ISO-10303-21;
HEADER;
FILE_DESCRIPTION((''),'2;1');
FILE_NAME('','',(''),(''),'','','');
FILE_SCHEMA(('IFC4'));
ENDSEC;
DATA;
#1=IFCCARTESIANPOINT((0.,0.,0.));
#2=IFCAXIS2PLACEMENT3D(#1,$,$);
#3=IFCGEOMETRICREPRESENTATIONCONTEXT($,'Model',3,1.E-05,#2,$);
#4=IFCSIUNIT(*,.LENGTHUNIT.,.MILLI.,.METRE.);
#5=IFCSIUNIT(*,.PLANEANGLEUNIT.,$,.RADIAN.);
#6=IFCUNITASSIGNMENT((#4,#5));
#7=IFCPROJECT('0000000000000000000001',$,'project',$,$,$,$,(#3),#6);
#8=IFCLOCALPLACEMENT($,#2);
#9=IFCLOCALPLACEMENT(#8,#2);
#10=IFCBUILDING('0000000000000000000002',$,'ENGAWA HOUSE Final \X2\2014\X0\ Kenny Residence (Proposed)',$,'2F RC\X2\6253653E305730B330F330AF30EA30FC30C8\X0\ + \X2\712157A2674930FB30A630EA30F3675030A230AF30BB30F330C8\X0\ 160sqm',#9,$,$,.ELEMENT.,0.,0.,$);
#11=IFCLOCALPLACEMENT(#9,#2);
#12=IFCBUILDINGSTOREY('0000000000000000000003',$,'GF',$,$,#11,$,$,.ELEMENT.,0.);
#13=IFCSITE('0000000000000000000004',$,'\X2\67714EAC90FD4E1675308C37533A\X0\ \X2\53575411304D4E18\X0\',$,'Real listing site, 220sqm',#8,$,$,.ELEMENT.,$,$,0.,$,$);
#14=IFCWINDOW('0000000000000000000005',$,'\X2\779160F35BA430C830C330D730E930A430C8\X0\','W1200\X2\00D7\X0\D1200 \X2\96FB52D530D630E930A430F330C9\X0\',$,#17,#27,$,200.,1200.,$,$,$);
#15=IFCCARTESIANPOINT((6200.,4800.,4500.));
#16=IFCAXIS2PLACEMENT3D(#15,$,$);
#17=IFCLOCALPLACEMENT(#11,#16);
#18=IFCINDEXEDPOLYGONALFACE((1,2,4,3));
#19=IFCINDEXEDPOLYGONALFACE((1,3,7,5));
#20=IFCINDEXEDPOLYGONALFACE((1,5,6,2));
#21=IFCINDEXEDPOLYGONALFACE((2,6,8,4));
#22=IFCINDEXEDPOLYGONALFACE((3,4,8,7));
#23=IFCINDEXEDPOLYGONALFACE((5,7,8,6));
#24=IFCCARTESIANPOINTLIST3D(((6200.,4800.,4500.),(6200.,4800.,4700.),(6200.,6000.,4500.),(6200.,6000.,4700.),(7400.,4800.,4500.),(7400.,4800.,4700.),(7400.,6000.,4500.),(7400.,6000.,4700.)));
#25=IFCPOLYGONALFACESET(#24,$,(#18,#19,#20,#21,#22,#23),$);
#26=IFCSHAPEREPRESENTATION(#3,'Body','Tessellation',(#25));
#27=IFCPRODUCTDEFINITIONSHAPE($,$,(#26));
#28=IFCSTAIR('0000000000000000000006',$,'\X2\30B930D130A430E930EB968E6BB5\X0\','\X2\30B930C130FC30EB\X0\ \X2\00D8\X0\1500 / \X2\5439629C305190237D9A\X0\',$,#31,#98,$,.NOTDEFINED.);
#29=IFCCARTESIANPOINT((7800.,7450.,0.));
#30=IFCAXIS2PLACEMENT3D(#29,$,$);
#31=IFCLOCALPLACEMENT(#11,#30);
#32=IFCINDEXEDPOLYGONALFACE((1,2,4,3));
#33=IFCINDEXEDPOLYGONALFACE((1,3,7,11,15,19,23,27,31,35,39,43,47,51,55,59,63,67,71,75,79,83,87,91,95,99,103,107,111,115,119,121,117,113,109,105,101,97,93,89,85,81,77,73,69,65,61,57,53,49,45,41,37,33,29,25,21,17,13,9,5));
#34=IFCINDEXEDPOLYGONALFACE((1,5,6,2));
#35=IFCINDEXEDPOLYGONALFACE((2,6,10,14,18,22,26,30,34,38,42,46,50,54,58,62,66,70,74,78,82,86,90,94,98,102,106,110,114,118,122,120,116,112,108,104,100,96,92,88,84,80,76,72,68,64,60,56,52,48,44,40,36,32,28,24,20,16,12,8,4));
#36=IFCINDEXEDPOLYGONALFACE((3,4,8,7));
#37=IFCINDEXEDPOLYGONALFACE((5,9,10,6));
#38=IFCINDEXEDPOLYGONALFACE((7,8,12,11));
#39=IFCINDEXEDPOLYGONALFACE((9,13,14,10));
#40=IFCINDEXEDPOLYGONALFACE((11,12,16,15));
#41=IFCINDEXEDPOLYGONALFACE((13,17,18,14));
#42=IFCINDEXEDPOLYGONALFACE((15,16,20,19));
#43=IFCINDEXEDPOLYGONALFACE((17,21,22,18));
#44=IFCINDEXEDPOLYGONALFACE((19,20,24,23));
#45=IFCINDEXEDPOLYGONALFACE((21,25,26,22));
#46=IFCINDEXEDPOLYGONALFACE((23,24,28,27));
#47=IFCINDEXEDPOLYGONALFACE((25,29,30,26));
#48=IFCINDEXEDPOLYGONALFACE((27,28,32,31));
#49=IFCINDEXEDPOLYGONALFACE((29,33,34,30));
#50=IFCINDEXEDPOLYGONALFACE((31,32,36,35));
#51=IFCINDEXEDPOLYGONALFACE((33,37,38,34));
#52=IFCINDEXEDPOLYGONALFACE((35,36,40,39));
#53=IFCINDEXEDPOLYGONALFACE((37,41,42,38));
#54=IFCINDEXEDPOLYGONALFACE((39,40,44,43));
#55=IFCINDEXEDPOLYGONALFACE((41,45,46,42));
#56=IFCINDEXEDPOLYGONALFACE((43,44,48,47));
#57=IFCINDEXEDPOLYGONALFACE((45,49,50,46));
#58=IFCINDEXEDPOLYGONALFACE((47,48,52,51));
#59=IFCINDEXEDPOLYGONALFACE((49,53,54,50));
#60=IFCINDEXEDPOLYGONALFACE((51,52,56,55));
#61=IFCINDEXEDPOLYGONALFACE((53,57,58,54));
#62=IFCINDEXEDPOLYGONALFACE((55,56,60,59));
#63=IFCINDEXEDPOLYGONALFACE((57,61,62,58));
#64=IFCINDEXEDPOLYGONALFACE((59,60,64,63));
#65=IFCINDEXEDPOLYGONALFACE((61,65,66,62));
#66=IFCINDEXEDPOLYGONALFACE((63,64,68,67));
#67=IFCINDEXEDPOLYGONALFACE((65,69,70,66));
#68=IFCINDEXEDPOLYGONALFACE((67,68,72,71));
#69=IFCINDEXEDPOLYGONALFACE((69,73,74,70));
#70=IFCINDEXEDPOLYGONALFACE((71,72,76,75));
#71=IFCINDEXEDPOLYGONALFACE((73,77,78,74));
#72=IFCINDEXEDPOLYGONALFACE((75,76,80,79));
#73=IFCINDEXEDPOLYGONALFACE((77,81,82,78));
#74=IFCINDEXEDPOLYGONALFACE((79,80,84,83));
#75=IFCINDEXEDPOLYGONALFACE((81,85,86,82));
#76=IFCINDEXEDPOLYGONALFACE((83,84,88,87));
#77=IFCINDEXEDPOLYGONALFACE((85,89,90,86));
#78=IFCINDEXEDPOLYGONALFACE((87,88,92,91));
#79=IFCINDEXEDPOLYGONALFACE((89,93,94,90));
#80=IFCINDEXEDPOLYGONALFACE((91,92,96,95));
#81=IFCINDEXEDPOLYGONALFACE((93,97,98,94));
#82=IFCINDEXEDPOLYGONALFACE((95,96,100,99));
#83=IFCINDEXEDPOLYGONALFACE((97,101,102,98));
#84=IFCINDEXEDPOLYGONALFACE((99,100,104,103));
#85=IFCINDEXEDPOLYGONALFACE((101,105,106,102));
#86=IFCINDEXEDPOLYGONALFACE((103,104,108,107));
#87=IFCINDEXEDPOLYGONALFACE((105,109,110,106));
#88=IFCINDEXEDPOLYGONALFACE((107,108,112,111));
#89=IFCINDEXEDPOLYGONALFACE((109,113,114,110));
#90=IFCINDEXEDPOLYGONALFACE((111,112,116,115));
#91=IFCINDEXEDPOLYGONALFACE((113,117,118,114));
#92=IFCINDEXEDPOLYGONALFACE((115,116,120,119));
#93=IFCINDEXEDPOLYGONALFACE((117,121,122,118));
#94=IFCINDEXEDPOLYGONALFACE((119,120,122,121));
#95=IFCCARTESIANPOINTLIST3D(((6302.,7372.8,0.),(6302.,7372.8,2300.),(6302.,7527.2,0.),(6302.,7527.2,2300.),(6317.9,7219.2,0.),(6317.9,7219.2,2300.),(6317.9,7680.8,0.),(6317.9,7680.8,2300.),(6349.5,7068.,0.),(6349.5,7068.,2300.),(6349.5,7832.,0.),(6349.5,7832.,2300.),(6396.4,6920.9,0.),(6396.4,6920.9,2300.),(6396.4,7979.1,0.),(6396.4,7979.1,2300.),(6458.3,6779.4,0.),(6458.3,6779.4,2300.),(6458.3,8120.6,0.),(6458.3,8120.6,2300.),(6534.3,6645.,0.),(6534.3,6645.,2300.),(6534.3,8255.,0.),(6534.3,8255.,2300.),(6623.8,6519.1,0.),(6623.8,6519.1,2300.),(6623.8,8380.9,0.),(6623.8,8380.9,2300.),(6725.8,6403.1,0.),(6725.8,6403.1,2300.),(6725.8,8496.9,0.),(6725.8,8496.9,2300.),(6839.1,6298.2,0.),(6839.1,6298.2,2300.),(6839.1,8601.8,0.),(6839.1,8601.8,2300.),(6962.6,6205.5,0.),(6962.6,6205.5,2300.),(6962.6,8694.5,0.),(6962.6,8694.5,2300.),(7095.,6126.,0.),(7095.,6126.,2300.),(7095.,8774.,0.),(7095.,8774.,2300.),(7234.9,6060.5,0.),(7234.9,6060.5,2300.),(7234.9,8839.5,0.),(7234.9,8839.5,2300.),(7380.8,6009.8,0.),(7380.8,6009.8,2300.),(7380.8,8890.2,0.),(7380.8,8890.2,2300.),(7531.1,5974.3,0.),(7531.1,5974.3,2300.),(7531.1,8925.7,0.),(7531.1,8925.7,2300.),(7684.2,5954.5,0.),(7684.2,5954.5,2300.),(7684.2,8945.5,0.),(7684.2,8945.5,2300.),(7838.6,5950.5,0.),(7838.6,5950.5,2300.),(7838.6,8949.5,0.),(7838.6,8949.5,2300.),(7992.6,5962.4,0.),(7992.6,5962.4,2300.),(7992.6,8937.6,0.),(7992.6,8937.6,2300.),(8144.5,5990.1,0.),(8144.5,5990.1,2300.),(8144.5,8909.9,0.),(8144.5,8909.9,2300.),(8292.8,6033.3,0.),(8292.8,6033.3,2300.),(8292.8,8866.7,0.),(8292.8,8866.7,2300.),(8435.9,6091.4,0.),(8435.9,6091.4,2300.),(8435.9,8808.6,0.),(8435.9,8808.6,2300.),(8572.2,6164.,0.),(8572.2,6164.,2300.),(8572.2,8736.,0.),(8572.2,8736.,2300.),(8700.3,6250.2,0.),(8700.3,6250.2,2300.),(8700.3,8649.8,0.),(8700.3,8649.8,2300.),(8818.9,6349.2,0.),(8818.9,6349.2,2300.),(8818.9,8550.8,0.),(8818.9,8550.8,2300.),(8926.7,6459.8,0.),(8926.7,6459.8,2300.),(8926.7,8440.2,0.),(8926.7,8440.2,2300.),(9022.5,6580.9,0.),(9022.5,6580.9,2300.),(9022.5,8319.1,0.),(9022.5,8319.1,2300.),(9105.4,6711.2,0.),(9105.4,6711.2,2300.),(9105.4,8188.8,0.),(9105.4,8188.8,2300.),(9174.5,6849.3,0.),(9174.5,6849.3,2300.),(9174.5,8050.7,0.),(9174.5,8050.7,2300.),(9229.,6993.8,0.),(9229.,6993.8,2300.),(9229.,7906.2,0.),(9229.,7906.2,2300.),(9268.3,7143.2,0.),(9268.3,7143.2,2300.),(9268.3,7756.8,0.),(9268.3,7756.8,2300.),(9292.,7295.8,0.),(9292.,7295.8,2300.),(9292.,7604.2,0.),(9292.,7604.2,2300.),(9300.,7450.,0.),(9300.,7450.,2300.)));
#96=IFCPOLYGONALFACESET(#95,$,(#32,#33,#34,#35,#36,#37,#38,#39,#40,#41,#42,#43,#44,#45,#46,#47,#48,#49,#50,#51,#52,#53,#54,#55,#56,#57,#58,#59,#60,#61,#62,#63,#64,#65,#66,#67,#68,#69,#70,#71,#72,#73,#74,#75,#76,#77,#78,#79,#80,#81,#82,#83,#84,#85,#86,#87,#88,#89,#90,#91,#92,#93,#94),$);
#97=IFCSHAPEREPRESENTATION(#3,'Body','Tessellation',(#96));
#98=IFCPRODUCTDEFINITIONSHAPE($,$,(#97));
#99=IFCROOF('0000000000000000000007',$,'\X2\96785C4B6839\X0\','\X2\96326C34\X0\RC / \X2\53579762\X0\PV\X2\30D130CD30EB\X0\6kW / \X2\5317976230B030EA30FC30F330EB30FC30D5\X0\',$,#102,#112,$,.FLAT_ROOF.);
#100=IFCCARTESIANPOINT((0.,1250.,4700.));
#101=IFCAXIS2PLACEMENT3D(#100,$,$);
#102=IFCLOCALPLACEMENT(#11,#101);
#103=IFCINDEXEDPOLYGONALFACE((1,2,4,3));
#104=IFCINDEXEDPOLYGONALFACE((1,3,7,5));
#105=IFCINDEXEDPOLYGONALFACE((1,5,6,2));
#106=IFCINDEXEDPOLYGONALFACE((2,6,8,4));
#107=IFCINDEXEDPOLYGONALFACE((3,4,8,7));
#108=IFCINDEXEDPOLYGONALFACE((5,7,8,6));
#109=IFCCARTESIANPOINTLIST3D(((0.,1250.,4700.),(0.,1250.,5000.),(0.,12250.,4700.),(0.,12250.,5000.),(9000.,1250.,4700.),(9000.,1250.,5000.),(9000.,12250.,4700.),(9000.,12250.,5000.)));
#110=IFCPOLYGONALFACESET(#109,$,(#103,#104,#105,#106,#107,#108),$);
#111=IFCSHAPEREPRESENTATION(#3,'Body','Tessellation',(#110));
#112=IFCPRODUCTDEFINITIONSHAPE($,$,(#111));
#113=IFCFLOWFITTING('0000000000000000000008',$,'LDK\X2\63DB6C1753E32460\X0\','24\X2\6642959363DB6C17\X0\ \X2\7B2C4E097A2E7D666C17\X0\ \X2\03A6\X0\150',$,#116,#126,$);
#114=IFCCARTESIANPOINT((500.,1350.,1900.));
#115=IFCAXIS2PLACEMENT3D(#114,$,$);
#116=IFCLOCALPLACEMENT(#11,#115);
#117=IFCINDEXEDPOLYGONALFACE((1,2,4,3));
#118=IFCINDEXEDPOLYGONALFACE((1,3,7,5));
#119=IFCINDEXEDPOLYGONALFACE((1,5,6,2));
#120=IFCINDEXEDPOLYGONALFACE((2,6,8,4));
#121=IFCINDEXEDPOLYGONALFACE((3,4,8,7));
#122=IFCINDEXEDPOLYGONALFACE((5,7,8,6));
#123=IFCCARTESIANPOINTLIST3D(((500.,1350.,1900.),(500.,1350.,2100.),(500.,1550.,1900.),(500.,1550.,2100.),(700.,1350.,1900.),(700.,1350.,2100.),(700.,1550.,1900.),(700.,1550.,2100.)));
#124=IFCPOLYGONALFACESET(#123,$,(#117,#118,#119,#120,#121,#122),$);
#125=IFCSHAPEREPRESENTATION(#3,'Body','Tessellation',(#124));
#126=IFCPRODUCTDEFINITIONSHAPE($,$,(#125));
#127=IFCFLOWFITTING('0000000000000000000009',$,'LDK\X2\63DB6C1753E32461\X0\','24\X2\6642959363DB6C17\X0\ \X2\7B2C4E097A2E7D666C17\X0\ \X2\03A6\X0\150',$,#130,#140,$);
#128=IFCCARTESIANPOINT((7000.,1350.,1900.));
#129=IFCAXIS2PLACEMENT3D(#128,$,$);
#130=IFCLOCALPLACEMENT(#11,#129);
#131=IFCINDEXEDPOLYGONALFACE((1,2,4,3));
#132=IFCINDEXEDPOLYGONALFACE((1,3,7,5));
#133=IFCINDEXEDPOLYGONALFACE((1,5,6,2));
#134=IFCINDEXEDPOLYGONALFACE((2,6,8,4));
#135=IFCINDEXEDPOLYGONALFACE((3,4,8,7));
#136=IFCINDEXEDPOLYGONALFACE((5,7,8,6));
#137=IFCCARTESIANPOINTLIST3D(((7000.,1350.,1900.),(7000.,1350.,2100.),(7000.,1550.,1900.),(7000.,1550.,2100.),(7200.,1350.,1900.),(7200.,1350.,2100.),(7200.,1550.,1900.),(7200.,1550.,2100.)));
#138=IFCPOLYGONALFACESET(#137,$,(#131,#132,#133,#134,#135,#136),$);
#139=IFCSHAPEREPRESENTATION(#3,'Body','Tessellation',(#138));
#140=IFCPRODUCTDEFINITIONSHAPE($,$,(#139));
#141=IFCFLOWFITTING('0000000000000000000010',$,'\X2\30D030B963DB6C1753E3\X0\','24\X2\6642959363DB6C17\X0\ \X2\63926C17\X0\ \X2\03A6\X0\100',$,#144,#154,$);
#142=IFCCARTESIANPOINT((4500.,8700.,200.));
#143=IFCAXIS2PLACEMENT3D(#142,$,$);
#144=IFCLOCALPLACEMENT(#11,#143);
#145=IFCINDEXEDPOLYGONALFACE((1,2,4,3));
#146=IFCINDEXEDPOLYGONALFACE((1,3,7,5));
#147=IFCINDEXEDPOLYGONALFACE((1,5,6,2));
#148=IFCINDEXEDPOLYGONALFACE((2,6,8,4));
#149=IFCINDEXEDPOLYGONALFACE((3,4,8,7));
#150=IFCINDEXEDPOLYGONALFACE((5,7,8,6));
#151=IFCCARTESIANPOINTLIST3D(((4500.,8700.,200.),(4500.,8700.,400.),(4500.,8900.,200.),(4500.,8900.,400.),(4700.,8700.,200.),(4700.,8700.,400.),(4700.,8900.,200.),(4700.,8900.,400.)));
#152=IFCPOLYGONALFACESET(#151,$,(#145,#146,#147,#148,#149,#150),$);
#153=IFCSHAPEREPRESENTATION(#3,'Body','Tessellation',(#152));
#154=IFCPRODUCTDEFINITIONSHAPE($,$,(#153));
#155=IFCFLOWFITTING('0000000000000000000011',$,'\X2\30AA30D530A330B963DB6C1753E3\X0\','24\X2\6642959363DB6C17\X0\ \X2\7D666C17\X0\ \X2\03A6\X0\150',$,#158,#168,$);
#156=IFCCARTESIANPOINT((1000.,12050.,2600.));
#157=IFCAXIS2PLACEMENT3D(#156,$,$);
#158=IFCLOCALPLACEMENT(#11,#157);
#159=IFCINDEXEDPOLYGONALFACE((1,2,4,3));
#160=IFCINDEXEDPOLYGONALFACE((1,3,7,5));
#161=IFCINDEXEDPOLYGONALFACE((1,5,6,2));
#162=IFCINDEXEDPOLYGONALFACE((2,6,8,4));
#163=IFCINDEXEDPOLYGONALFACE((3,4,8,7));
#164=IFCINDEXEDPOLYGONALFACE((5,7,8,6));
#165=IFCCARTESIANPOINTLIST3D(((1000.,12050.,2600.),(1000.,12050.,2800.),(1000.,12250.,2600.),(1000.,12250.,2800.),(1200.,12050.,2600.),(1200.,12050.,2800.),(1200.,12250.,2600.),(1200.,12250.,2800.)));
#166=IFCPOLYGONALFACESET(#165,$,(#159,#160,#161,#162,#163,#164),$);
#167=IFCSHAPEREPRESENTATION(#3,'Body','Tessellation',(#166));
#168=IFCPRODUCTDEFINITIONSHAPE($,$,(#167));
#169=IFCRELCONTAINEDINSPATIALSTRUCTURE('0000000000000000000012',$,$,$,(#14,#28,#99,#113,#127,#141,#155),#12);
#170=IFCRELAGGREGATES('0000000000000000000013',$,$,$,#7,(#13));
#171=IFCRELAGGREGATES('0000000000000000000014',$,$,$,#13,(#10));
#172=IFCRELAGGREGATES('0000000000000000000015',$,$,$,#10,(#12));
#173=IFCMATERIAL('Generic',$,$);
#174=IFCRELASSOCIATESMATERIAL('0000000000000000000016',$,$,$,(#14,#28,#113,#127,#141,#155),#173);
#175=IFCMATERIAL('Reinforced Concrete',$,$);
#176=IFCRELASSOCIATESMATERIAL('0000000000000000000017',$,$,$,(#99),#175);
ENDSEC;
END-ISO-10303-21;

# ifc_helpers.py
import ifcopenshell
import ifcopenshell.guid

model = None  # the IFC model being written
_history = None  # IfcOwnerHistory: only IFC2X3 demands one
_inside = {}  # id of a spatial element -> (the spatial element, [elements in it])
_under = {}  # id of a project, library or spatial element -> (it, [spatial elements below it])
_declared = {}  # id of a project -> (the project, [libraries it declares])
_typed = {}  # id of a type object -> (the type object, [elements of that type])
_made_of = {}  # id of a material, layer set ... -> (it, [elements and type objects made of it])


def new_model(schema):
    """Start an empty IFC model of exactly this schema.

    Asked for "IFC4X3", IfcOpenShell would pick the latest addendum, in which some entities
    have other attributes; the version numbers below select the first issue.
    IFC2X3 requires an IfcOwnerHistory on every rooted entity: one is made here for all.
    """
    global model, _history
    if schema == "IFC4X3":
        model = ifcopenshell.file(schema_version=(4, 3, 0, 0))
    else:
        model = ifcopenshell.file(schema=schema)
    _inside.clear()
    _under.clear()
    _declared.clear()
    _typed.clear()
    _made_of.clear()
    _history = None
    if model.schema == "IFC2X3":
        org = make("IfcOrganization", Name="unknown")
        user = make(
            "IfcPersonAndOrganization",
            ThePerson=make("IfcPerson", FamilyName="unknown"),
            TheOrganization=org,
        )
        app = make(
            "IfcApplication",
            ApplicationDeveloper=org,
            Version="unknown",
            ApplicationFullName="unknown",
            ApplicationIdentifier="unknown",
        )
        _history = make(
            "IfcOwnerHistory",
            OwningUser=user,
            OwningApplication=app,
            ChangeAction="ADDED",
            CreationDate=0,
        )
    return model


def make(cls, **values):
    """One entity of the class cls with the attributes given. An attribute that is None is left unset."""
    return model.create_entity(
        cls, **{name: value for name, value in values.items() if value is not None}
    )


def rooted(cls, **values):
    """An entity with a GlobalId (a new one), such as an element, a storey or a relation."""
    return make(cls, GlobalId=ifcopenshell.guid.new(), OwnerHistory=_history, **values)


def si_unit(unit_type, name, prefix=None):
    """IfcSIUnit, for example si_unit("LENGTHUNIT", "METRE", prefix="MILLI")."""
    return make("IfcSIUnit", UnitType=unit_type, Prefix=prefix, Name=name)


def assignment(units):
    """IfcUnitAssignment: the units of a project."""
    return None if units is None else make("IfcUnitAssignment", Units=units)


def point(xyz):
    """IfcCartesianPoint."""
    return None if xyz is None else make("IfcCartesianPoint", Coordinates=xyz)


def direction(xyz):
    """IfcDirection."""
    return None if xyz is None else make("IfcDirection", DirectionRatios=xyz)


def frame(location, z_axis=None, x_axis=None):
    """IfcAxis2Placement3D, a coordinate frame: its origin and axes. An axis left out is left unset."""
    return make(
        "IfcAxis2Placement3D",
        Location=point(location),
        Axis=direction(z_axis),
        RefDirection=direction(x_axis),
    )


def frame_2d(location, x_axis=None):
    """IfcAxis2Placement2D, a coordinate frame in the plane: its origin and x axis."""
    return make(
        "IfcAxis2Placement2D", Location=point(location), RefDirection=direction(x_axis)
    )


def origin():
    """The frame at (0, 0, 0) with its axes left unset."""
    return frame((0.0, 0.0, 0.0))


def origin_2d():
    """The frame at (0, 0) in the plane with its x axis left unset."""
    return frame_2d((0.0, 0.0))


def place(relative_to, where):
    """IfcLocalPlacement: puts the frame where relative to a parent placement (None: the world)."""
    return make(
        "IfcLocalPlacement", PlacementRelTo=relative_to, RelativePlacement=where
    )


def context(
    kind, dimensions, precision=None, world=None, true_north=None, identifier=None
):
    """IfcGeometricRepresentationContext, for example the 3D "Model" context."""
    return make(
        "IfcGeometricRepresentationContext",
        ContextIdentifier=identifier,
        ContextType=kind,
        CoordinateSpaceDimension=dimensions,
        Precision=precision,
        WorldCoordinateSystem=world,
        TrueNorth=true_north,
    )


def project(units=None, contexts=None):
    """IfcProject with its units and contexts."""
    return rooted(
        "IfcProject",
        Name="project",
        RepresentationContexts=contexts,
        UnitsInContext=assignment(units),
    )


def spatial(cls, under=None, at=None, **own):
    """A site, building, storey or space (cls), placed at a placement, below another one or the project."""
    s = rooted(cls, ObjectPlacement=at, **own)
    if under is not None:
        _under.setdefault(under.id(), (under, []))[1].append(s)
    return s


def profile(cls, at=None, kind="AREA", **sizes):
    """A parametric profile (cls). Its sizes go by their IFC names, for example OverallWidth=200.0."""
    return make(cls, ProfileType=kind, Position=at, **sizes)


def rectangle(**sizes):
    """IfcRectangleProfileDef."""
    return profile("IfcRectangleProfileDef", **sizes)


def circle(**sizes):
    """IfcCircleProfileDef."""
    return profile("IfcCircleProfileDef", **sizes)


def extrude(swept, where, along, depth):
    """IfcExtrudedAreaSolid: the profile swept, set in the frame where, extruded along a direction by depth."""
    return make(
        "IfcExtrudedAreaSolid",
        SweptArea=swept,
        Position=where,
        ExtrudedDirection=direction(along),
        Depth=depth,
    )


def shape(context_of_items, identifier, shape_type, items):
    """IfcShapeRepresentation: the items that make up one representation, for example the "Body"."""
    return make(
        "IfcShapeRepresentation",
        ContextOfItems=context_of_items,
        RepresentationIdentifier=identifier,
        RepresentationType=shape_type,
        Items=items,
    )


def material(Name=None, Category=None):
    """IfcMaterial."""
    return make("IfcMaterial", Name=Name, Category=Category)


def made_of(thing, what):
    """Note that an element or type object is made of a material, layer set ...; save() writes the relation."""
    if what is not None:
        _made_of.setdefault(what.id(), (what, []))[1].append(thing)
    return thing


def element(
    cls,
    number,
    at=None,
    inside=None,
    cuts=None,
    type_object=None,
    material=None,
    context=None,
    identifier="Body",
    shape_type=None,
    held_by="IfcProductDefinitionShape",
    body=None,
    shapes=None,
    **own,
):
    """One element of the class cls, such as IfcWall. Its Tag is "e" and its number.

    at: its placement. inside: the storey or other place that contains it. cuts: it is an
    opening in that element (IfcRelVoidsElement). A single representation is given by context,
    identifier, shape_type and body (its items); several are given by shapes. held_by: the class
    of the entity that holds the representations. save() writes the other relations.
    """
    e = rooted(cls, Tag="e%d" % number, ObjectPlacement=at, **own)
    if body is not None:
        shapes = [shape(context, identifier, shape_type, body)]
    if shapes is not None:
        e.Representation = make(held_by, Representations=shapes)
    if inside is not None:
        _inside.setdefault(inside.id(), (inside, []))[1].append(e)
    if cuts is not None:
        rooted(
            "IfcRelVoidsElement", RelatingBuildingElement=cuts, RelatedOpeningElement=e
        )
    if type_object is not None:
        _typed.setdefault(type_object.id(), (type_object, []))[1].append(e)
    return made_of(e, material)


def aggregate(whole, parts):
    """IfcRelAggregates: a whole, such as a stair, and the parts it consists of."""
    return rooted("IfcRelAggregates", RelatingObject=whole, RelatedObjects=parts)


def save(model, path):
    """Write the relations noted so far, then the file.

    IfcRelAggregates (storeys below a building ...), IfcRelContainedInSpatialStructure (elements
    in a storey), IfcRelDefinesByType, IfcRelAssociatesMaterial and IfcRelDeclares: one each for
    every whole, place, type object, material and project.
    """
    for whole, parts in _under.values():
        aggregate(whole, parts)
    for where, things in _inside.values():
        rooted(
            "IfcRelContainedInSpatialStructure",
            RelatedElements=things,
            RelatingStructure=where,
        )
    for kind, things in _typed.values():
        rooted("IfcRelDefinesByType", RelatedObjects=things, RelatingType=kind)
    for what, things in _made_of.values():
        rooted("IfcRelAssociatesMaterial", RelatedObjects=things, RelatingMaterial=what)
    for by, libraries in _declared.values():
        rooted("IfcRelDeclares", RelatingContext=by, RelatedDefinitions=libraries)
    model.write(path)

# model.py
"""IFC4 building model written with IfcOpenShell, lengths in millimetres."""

from ifc_helpers import new_model, si_unit, frame, frame_2d, origin, origin_2d, place, context, project, spatial, rectangle, circle, extrude, material, element, save


model = new_model("IFC4")

# Units and contexts
model_context = context("Model", 3, precision=1e-05, world=origin())
ifc_project = project(units=[si_unit("LENGTHUNIT", "METRE", prefix="MILLI"), si_unit("PLANEANGLEUNIT", "RADIAN")], contexts=[model_context])

# Site, building, storey
site_placement = place(None, origin())
site = spatial("IfcSite", under=ifc_project, at=site_placement, Name="東京都世田谷区 南向き丘", ObjectType="Real listing site, 220sqm", CompositionType="ELEMENT", RefElevation=0.0)
building_placement = place(site_placement, origin())
building = spatial("IfcBuilding", under=site, at=building_placement, Name="ENGAWA HOUSE Final — Kenny Residence (Proposed)", ObjectType="2F RC打放しコンクリート + 無垢杉・ウリン材アクセント 160sqm", CompositionType="ELEMENT", ElevationOfRefHeight=0.0, ElevationOfTerrain=0.0)
storey_placement = place(building_placement, origin())
storey = spatial("IfcBuildingStorey", under=building, at=storey_placement, Name="GF", CompositionType="ELEMENT", Elevation=0.0)

# Shared definitions
ifc_material_1 = material(Name="Reinforced Concrete")
ifc_material_2 = material(Name="Generic")

# Window
window_1_placement = place(storey_placement, frame((6200.0, 4800.0, 4500.0)))
element("IfcWindow", 1, at=window_1_placement, inside=storey, material=ifc_material_2, Name="瞑想室トップライト", Description="W1200×D1200 電動ブラインド", OverallHeight=200.0, OverallWidth=1200.0, context=model_context, shape_type="SweptSolid", body=[
    extrude(rectangle(XDim=1200.0, YDim=1200.0, at=frame_2d((600.0, 600.0))), frame((6200.0, 4800.0, 4500.0)), (0.0, 0.0, 1.0), 200.0),
])

# Stair
stair_placement = place(storey_placement, frame((7800.0, 7450.0, 0.0)))
element("IfcStair", 2, at=stair_placement, inside=storey, material=ifc_material_2, Name="スパイラル階段", Description="スチール Ø1500 / 吹抜け連続", PredefinedType="NOTDEFINED", context=model_context, shape_type="SweptSolid", body=[
    extrude(circle(Radius=1500.0, at=origin_2d()), frame((7800.0, 7450.0, 0.0)), (0.0, 0.0, 1.0), 2300.0),
])

# Roof
roof_placement = place(storey_placement, frame((0.0, 1250.0, 4700.0)))
element("IfcRoof", 3, at=roof_placement, inside=storey, material=ifc_material_1, Name="陸屋根", Description="防水RC / 南面PVパネル6kW / 北面グリーンルーフ", PredefinedType="FLAT_ROOF", context=model_context, shape_type="SweptSolid", body=[
    extrude(rectangle(XDim=9000.0, YDim=11000.0, at=frame_2d((4500.0, 5500.0))), frame((0.0, 1250.0, 4700.0)), (0.0, 0.0, 1.0), 300.0),
])

# Flow fittings
flow_fitting_1_placement = place(storey_placement, frame((500.0, 1350.0, 1900.0)))
element("IfcFlowFitting", 4, at=flow_fitting_1_placement, inside=storey, material=ifc_material_2, Name="LDK換気口①", Description="24時間換気 第三種給気 Φ150", context=model_context, shape_type="SweptSolid", body=[
    extrude(rectangle(XDim=200.0, YDim=200.0, at=frame_2d((100.0, 100.0))), frame((500.0, 1350.0, 1900.0)), (0.0, 0.0, 1.0), 200.0),
])
flow_fitting_2_placement = place(storey_placement, frame((7000.0, 1350.0, 1900.0)))
element("IfcFlowFitting", 5, at=flow_fitting_2_placement, inside=storey, material=ifc_material_2, Name="LDK換気口②", Description="24時間換気 第三種給気 Φ150", context=model_context, shape_type="SweptSolid", body=[
    extrude(rectangle(XDim=200.0, YDim=200.0, at=frame_2d((100.0, 100.0))), frame((7000.0, 1350.0, 1900.0)), (0.0, 0.0, 1.0), 200.0),
])
flow_fitting_3_placement = place(storey_placement, frame((4500.0, 8700.0, 200.0)))
element("IfcFlowFitting", 6, at=flow_fitting_3_placement, inside=storey, material=ifc_material_2, Name="バス換気口", Description="24時間換気 排気 Φ100", context=model_context, shape_type="SweptSolid", body=[
    extrude(rectangle(XDim=200.0, YDim=200.0, at=frame_2d((100.0, 100.0))), frame((4500.0, 8700.0, 200.0)), (0.0, 0.0, 1.0), 200.0),
])
flow_fitting_4_placement = place(storey_placement, frame((1000.0, 12050.0, 2600.0)))
element("IfcFlowFitting", 7, at=flow_fitting_4_placement, inside=storey, material=ifc_material_2, Name="オフィス換気口", Description="24時間換気 給気 Φ150", context=model_context, shape_type="SweptSolid", body=[
    extrude(rectangle(XDim=200.0, YDim=200.0, at=frame_2d((100.0, 100.0))), frame((1000.0, 12050.0, 2600.0)), (0.0, 0.0, 1.0), 200.0),
])

save(model, "model.ifc")
